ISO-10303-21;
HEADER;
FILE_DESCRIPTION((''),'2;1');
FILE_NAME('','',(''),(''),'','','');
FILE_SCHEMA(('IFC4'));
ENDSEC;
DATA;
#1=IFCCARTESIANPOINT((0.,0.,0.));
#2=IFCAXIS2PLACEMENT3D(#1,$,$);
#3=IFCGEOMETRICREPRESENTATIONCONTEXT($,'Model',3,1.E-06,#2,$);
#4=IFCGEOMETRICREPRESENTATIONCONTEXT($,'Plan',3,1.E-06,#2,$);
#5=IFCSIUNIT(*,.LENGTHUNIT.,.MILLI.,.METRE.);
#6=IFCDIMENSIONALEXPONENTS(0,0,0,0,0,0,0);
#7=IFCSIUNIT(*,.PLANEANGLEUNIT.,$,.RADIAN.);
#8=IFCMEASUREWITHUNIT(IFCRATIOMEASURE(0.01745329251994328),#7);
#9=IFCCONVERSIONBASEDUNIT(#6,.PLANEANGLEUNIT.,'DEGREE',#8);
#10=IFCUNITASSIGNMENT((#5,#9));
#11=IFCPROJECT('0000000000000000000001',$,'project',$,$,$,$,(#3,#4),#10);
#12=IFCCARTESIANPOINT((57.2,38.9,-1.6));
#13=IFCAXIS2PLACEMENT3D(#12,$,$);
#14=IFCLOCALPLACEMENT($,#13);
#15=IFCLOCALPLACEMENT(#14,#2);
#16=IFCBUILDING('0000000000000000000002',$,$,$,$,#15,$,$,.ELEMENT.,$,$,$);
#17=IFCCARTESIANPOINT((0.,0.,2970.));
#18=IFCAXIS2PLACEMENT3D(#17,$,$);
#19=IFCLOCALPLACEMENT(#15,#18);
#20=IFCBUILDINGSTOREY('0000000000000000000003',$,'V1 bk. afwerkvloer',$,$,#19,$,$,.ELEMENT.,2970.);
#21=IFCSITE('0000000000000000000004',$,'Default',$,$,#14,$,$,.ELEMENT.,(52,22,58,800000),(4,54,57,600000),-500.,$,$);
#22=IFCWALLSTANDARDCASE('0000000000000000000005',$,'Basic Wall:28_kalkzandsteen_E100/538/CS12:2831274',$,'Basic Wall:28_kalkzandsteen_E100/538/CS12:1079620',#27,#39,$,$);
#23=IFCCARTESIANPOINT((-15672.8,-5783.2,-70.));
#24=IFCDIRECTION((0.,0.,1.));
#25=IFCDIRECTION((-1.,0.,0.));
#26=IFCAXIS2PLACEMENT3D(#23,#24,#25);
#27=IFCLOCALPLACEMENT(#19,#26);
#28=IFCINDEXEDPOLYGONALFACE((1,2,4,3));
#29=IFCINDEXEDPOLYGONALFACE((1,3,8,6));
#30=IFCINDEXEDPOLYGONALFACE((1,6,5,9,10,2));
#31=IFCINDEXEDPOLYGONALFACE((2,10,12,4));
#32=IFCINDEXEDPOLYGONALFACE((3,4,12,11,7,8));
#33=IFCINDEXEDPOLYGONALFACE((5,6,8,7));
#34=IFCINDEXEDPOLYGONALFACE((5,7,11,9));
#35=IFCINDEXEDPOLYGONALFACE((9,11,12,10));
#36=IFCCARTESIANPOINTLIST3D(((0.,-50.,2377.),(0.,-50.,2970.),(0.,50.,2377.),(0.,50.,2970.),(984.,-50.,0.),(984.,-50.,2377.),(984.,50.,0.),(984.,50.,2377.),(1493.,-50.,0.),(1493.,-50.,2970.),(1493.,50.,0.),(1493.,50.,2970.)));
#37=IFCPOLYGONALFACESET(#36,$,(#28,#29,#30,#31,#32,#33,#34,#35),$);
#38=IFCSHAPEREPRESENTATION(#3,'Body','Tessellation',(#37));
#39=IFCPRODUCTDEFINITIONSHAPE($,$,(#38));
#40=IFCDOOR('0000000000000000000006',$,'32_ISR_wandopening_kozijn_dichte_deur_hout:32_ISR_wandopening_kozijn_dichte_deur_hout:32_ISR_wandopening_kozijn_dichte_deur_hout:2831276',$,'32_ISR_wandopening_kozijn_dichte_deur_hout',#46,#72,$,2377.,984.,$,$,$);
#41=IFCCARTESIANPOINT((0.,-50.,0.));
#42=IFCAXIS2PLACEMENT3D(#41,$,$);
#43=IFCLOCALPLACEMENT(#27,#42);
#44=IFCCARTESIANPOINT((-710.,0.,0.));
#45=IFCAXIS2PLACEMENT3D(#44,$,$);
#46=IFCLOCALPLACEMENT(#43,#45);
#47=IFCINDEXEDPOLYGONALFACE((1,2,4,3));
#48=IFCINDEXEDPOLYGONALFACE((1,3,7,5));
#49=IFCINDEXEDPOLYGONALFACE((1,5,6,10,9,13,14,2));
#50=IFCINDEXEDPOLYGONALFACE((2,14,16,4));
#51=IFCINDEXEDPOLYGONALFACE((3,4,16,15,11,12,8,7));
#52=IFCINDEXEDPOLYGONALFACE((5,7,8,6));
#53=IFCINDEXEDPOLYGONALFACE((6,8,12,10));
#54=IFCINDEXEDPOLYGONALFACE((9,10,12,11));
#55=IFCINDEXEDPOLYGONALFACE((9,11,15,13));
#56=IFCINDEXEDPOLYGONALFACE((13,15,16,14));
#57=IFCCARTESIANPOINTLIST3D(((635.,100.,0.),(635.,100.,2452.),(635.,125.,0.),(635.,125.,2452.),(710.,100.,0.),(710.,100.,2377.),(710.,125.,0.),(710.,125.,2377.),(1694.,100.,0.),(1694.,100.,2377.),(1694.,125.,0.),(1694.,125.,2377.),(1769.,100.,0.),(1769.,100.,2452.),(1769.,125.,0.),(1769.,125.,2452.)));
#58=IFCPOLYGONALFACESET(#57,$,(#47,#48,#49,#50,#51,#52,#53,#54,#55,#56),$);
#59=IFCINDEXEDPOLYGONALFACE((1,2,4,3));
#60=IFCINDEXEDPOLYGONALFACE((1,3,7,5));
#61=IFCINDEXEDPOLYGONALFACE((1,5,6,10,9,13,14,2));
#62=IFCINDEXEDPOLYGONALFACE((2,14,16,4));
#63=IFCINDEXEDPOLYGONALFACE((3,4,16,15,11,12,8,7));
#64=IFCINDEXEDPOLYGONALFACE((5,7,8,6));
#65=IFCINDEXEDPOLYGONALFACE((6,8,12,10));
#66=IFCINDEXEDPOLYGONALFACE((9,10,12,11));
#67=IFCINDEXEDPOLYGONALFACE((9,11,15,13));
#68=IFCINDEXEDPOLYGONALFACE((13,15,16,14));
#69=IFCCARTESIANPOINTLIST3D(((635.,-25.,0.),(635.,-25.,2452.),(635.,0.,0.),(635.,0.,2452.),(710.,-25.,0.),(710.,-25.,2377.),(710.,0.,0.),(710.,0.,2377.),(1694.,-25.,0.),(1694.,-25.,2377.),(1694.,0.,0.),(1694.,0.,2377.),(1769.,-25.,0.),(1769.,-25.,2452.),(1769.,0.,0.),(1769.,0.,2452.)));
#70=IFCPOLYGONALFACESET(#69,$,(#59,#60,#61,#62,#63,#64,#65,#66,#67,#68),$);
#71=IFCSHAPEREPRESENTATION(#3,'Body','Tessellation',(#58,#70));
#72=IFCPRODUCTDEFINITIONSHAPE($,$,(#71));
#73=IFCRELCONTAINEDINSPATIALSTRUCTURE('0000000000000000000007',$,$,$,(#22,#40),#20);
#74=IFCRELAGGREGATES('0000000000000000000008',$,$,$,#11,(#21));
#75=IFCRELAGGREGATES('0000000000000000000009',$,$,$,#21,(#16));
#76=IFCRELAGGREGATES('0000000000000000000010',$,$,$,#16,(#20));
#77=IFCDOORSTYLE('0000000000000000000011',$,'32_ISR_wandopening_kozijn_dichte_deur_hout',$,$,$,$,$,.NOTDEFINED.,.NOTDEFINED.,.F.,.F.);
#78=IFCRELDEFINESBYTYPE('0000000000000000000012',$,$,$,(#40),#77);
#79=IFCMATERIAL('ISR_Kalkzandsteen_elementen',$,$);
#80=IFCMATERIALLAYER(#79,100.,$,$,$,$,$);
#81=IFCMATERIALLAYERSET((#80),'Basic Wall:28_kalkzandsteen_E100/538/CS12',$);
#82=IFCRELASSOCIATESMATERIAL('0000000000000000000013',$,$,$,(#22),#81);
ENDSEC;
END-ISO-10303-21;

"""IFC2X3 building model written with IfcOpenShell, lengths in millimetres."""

from ifc_helpers import new_model, entity, si_unit, converted_unit, frame, frame_2d, origin, place, context, project, spatial, polyline, rectangle, outline, extrude, source, transform, mapped, material, layer, layer_set, layer_usage, type_object, type_shapes, element, fill, save


model = new_model("IFC2X3")

# Units and contexts
model_context = context("Model", 3, precision=1e-06, world=origin())
plan_context = context("Plan", 3, precision=1e-06, world=origin())
ifc_project = project(units=[si_unit("LENGTHUNIT", "METRE", prefix="MILLI"), converted_unit("PLANEANGLEUNIT", "DEGREE", entity("IfcRatioMeasure", 0.01745329251994328), si_unit("PLANEANGLEUNIT", "RADIAN"), dimensions=[0, 0, 0, 0, 0, 0, 0])], contexts=[model_context, plan_context])

# Site, building, storey
site_placement = place(None, frame((57.2, 38.9, -1.6)))
site = spatial("IfcSite", under=ifc_project, at=site_placement, Name="Default", CompositionType="ELEMENT", RefLatitude=(52, 22, 58, 800000), RefLongitude=(4, 54, 57, 600000), RefElevation=-500.0)
building_placement = place(site_placement, origin())
building = spatial("IfcBuilding", under=site, at=building_placement, CompositionType="ELEMENT")
storey_placement = place(building_placement, frame((0.0, 0.0, 2970.0)))
storey = spatial("IfcBuildingStorey", under=building, at=storey_placement, Name="V1 bk. afwerkvloer", CompositionType="ELEMENT", Elevation=2970.0)

# Shared definitions
ifc_material_1 = material(Name="ISR_Kalkzandsteen_elementen")
ifc_layer_1 = layer(ifc_material_1, 100.0)
ifc_layer_set_1 = layer_set([ifc_layer_1], Name="Basic Wall:28_kalkzandsteen_E100/538/CS12")

# Shared definitions
door_style_1 = type_object("IfcDoorStyle", Name="32_ISR_wandopening_kozijn_dichte_deur_hout", ConstructionType="NOTDEFINED", OperationType="NOTDEFINED", ParameterTakesPrecedence=False, Sizeable=False)
shared_shape_1 = source(origin(), model_context, "Body", "SweptSolid", [
    extrude(outline(polyline([(-1169.7, 492.0), (1207.2, 492.0), (1207.2, 567.0), (-1244.7, 567.0), (-1244.7, -567.0), (1207.2, -567.0), (1207.2, -492.0), (-1169.7, -492.0), (-1169.7, 492.0)])), frame((1202.0, 125.0, 1207.2), z_axis=(0.0, -1.0, 0.0), x_axis=(0.0, 0.0, -1.0)), (0.0, 0.0, 1.0), 25.0),
    extrude(outline(polyline([(-567.0, -1244.7), (567.0, -1244.7), (567.0, 1207.2), (492.0, 1207.2), (492.0, -1169.7), (-492.0, -1169.7), (-492.0, 1207.2), (-567.0, 1207.2), (-567.0, -1244.7)])), frame((1202.0, 0.0, 1207.2), z_axis=(0.0, -1.0, 0.0), x_axis=(-1.0, 0.0, 0.0)), (0.0, 0.0, 1.0), 25.0),
])
type_shapes(door_style_1, [shared_shape_1])

# Wall, opening, door
ifc_layer_usage_1 = layer_usage(ifc_layer_set_1, "AXIS2", "POSITIVE", -50.0)
wall_1_placement = place(storey_placement, frame((-15672.8, -5783.2, -70.0), z_axis=(0.0, 0.0, 1.0), x_axis=(-1.0, 0.0, 0.0)))
wall_1 = element("IfcWallStandardCase", 1, at=wall_1_placement, inside=storey, material=ifc_layer_usage_1, Name="Basic Wall:28_kalkzandsteen_E100/538/CS12:2831274", ObjectType="Basic Wall:28_kalkzandsteen_E100/538/CS12:1079620", context=model_context, shape_type="SweptSolid", body=[
    extrude(rectangle(XDim=1493.0, YDim=100.0, at=frame_2d((746.5, 0.0), x_axis=(-1.0, 0.0))), origin(), (0.0, 0.0, 1.0), 2970.0),
])
opening_1_placement = place(wall_1_placement, frame((0.0, -50.0, 0.0)))
opening_1 = element("IfcOpeningElement", 2, at=opening_1_placement, cuts=wall_1, ObjectType="Opening", context=model_context, shape_type="SweptSolid", body=[
    extrude(rectangle(XDim=2377.0, YDim=984.0, at=frame_2d((1188.5, 492.0), x_axis=(1.0, 0.0))), frame((0.0, 0.0, 0.0), z_axis=(0.0, 1.0, 0.0), x_axis=(0.0, 0.0, 1.0)), (0.0, 0.0, 1.0), 100.0),
])
door_1_placement = place(opening_1_placement, frame((-710.0, 0.0, 0.0)))
door_1 = element("IfcDoor", 3, at=door_1_placement, inside=storey, type_object=door_style_1, Name="32_ISR_wandopening_kozijn_dichte_deur_hout:32_ISR_wandopening_kozijn_dichte_deur_hout:32_ISR_wandopening_kozijn_dichte_deur_hout:2831276", ObjectType="32_ISR_wandopening_kozijn_dichte_deur_hout", OverallHeight=2377.0, OverallWidth=984.0, context=model_context, shape_type="MappedRepresentation", body=[
    mapped(shared_shape_1, transform((0.0, 0.0, 0.0), scale=1.0)),
])
fill(opening_1, door_1)

save(model, "model.ifc")
